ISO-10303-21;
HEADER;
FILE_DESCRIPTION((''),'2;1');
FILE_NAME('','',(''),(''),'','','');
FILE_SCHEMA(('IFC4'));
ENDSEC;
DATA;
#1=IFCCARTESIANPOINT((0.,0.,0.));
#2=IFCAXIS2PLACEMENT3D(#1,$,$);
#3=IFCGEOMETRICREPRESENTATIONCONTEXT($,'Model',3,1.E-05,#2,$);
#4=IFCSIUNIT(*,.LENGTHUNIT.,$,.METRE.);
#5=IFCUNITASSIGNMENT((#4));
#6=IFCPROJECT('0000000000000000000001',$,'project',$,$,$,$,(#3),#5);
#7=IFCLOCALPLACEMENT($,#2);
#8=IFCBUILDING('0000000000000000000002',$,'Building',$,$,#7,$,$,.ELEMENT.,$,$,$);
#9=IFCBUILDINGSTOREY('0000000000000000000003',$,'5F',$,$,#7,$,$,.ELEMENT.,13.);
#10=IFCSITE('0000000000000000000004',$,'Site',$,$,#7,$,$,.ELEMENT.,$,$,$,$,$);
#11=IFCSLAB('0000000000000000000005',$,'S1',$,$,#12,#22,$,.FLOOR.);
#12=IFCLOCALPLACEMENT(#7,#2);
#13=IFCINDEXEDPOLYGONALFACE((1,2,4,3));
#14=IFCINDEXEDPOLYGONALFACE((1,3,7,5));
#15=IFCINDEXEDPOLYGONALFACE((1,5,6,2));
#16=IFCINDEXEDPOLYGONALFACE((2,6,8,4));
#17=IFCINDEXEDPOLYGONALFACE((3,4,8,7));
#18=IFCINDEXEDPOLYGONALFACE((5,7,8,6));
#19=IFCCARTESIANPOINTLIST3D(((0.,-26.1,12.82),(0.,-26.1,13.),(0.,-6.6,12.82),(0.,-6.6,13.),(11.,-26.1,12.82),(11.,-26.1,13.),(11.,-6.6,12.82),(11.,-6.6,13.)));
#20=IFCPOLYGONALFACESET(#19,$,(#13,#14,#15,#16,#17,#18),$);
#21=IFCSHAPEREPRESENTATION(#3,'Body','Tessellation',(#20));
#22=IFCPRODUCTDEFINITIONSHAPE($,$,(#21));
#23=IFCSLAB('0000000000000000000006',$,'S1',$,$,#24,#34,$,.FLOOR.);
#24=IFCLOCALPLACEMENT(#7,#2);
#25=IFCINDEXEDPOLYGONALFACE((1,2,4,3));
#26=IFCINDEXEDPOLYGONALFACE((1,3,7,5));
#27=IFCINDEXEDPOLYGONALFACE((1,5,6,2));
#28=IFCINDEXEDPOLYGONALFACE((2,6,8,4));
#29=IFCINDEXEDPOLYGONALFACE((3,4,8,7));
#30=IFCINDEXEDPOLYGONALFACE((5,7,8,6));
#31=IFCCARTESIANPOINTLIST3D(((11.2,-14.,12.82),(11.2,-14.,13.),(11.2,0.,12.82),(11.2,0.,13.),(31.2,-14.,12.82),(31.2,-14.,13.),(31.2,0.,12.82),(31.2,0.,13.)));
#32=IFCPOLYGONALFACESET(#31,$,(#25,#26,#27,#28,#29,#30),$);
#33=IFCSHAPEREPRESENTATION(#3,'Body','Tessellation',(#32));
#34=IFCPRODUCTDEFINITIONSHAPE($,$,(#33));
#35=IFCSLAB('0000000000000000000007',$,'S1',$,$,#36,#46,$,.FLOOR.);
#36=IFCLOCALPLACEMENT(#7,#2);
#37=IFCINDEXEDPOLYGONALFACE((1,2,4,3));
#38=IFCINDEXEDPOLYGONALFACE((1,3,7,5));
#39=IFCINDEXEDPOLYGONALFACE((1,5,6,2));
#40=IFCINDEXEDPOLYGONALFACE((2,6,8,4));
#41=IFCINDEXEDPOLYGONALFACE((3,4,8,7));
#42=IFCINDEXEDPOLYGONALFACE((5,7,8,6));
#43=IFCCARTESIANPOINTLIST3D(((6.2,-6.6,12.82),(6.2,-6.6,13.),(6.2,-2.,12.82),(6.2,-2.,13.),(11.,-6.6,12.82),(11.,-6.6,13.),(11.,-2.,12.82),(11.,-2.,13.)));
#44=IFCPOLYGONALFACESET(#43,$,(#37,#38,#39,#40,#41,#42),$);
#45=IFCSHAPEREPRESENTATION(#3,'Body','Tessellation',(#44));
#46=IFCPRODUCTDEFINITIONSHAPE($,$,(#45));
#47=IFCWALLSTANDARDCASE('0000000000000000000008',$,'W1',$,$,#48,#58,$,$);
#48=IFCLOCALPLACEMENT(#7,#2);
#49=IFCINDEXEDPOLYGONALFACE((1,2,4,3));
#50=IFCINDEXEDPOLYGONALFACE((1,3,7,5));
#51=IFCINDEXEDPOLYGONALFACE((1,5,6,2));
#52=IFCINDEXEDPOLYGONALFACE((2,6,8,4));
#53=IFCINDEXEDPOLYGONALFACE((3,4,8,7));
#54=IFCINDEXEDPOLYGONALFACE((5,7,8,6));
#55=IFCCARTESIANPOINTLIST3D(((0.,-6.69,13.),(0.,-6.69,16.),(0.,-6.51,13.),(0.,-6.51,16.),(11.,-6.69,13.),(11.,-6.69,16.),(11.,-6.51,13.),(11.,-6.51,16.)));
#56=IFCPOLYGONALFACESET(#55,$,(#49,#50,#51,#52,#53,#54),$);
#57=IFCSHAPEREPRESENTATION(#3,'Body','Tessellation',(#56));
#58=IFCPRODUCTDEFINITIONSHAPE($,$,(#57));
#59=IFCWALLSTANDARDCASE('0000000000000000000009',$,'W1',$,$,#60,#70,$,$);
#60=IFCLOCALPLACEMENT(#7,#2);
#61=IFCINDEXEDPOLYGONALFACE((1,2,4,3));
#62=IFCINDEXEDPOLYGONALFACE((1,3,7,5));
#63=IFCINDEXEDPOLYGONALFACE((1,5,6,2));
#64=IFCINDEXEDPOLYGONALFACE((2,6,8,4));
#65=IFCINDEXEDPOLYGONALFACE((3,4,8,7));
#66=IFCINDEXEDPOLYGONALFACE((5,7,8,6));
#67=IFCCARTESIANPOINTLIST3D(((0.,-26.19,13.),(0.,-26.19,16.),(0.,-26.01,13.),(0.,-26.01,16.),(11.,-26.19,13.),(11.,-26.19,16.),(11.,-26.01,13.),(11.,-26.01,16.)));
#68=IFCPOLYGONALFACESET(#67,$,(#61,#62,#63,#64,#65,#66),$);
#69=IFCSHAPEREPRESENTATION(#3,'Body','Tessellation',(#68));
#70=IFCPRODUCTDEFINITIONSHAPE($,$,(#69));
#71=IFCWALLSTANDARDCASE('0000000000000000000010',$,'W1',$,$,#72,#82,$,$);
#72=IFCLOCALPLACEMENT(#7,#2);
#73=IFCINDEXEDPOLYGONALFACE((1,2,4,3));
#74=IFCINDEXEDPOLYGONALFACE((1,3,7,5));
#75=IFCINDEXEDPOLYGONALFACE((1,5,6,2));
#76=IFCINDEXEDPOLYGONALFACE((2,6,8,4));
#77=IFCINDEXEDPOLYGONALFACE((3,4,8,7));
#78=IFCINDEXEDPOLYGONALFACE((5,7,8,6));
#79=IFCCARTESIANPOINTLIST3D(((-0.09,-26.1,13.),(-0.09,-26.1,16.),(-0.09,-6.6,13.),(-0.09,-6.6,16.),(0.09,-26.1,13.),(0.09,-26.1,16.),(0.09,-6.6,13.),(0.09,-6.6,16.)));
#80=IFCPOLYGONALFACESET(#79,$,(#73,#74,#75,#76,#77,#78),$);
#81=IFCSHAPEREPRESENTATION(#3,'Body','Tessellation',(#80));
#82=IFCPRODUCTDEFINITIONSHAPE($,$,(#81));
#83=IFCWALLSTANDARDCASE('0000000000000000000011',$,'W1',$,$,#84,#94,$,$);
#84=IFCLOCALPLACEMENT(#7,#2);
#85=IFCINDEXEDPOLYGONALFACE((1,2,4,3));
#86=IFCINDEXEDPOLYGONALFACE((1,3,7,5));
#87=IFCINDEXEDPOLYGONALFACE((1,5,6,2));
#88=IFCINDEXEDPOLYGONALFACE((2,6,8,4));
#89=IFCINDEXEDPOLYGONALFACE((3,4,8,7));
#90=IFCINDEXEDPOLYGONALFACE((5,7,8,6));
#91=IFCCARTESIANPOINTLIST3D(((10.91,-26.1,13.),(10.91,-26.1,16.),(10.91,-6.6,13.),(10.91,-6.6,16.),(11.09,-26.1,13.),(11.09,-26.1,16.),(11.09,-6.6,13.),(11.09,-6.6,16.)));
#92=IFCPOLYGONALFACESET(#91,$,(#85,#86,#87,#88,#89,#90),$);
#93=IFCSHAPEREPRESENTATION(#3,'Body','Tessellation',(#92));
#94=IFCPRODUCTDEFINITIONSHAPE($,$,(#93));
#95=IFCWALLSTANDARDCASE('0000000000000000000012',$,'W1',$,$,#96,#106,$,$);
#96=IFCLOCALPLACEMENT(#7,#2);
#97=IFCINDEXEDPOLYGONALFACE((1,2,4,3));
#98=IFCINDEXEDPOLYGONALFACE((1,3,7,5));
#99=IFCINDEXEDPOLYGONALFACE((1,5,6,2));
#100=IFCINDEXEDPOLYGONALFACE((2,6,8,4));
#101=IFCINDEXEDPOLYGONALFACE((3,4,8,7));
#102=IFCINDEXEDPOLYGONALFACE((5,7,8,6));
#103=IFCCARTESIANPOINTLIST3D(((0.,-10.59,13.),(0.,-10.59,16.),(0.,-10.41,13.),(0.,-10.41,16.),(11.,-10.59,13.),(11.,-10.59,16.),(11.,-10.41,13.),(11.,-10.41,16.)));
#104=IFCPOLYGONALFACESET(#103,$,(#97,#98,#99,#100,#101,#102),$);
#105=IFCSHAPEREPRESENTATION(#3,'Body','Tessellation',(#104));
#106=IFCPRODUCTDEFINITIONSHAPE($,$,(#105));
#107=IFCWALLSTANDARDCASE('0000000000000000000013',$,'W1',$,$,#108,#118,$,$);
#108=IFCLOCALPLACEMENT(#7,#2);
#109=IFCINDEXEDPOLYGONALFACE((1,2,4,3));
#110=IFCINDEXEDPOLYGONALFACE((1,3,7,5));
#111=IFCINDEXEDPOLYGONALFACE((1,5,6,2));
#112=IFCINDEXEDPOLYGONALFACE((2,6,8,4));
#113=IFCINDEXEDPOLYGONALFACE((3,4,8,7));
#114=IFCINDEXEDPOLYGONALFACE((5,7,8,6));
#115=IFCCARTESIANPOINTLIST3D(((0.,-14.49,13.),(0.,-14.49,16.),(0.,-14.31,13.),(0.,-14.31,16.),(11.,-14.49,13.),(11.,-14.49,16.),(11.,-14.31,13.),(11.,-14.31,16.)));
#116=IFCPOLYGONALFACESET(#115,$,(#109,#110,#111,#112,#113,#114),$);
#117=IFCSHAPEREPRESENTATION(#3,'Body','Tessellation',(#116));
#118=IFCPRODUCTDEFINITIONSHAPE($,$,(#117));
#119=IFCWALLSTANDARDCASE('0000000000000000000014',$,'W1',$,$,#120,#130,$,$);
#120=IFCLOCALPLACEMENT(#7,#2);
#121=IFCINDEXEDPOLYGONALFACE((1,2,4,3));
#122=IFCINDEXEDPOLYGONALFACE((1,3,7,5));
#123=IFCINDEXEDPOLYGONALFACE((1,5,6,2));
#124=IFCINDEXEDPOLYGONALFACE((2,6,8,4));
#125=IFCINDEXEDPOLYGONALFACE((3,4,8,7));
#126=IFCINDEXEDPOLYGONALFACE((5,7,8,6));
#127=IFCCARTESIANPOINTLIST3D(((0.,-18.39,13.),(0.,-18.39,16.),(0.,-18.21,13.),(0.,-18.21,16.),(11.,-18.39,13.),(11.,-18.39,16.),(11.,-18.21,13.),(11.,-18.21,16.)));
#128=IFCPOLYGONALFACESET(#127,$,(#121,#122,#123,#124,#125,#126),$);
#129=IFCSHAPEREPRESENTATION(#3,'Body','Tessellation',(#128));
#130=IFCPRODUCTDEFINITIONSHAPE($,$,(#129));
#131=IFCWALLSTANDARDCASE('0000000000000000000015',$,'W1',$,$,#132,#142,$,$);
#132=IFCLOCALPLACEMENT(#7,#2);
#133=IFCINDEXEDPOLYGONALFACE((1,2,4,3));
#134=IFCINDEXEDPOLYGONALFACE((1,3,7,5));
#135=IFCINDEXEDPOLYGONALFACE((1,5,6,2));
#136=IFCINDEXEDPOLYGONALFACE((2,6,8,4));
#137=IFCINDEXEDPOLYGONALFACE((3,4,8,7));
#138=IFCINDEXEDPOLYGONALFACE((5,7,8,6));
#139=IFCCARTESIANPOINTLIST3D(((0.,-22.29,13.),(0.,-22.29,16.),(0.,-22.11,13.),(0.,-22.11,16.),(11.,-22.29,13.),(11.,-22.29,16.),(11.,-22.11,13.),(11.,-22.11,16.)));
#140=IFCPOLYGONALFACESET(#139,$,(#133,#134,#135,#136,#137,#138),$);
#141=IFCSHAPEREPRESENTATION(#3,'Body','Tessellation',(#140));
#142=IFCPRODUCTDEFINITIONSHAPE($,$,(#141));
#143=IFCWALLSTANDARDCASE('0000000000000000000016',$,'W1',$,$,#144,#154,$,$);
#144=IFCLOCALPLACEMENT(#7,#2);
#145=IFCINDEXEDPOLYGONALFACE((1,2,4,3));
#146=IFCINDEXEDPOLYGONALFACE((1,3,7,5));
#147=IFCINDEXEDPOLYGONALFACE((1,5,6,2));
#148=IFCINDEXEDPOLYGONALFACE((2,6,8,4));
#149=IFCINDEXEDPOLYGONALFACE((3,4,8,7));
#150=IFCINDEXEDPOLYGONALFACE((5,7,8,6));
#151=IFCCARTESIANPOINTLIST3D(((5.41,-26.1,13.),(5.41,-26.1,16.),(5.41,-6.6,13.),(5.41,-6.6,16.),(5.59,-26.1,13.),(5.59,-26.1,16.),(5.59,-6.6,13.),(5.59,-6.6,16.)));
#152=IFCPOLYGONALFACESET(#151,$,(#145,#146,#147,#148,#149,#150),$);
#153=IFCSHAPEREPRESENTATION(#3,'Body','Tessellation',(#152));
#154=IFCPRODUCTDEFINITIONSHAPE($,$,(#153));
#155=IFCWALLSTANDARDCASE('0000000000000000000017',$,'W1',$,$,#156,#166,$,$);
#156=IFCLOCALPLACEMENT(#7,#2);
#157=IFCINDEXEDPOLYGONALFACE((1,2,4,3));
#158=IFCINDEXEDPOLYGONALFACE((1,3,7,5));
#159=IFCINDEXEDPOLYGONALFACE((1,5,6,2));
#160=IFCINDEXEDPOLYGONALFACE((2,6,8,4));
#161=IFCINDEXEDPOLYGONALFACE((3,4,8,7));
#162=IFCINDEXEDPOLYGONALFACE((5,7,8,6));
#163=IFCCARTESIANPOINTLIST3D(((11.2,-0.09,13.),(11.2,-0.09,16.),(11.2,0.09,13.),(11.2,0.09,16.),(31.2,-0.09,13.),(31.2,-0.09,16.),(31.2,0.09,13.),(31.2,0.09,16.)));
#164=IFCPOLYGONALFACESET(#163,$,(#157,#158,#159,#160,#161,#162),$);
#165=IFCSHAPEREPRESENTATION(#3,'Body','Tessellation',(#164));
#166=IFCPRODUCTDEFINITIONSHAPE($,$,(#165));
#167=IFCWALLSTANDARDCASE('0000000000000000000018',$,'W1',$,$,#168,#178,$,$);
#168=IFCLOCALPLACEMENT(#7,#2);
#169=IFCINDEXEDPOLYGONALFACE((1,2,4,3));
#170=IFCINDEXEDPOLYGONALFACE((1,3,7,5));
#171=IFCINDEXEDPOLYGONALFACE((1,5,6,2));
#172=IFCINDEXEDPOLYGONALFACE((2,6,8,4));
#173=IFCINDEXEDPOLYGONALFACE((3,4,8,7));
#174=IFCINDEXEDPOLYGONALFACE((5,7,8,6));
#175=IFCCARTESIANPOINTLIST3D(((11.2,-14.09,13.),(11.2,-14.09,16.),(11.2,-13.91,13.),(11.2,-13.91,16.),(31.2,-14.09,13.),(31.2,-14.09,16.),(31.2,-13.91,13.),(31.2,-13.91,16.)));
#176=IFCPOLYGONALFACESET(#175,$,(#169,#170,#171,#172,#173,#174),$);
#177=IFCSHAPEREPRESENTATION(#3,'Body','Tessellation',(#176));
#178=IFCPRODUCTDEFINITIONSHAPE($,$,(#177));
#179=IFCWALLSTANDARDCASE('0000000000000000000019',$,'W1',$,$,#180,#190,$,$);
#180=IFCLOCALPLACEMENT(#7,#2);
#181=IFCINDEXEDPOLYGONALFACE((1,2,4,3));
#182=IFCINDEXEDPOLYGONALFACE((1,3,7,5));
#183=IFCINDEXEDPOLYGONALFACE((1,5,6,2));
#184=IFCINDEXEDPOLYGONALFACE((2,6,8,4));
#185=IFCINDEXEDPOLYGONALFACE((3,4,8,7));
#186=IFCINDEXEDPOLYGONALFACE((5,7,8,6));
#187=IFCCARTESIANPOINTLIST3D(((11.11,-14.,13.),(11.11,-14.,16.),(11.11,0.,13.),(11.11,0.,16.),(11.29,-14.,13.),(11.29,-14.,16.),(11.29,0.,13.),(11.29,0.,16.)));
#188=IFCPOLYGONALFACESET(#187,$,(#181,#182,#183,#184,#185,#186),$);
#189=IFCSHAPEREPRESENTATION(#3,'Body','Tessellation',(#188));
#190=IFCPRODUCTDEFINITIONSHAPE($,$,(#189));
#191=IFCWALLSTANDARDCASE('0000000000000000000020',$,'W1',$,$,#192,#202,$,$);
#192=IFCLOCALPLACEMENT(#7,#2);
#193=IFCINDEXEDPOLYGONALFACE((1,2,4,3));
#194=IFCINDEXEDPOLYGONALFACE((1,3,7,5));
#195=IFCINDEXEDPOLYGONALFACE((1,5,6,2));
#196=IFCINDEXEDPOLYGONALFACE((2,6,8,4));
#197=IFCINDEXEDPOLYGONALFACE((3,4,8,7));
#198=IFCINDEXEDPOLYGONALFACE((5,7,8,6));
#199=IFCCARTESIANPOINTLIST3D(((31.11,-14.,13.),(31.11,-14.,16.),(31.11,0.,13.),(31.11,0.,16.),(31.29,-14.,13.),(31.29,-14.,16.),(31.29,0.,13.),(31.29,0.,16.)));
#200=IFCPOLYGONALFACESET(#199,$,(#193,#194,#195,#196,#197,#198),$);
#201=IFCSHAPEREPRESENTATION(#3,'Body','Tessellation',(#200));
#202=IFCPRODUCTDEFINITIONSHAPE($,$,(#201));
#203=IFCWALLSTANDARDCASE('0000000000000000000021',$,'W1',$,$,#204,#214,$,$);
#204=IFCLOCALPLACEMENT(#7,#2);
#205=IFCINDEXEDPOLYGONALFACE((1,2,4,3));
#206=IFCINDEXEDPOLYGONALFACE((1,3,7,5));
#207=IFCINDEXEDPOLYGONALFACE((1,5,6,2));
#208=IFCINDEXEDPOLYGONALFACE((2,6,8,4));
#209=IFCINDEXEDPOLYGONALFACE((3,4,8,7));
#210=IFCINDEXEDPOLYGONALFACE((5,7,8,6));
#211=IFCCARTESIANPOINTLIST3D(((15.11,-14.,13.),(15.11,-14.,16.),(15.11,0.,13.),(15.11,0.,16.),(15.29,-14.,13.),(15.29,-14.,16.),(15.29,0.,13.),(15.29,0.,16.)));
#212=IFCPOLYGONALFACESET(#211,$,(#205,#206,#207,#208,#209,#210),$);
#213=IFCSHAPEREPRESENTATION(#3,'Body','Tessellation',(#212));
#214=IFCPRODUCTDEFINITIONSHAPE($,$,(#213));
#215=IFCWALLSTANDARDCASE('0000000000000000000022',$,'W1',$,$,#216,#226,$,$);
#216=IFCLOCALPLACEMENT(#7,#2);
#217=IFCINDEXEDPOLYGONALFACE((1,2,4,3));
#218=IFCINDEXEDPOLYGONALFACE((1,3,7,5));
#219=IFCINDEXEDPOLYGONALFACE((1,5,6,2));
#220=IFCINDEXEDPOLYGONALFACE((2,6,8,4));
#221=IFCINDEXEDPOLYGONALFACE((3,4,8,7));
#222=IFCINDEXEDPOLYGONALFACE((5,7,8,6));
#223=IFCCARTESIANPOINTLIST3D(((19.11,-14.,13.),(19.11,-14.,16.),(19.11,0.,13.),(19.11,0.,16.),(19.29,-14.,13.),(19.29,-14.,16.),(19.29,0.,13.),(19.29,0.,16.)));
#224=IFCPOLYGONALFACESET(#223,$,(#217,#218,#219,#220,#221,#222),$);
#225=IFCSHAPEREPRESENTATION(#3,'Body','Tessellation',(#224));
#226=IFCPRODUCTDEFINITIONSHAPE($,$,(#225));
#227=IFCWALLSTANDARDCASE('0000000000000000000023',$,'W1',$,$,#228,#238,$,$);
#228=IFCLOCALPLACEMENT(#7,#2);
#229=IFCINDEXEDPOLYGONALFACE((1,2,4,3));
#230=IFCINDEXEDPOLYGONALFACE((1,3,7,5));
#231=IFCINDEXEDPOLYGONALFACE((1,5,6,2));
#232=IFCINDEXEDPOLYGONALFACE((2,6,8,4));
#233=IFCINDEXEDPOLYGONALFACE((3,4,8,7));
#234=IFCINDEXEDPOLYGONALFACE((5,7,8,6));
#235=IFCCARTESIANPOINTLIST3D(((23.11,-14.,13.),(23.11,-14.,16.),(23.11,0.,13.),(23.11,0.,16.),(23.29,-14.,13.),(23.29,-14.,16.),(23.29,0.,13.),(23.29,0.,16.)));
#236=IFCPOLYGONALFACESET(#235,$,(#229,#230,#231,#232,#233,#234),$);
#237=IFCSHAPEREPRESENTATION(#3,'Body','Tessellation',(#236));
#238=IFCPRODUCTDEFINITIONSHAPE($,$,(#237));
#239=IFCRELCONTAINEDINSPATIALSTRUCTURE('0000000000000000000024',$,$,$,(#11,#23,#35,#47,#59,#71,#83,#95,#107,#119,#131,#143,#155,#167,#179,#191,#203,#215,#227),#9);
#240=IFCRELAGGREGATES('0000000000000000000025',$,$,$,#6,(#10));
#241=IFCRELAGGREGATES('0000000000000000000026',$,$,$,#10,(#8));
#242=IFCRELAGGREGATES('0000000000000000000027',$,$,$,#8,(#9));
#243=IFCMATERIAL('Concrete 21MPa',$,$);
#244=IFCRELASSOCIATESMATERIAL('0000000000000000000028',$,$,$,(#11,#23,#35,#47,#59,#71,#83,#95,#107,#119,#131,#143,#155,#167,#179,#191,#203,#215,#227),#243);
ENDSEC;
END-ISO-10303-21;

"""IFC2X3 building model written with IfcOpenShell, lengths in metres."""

from ifc_helpers import new_model, si_unit, frame, origin, origin_2d, place, context, project, spatial, rectangle, extrude, material, element, save


model = new_model("IFC2X3")

# Units and contexts
model_context = context("Model", 3, precision=1e-05, world=origin())
ifc_project = project(units=[si_unit("LENGTHUNIT", "METRE")], contexts=[model_context])

# Site, building, storey
placement = place(None, origin())
site = spatial("IfcSite", under=ifc_project, at=placement, Name="Site", CompositionType="ELEMENT")
building = spatial("IfcBuilding", under=site, at=placement, Name="Building", CompositionType="ELEMENT")
storey = spatial("IfcBuildingStorey", under=building, at=placement, Name="5F", CompositionType="ELEMENT", Elevation=13.0)

# Slabs
ifc_material_1 = material(Name="Concrete 21MPa")
slab_1_placement = place(None, frame((5.5, -16.35, 12.82)))
element("IfcSlab", 1, at=slab_1_placement, inside=storey, material=ifc_material_1, Name="S1", PredefinedType="FLOOR", context=model_context, shape_type="SweptSolid", body=[
    extrude(rectangle(XDim=11.0, YDim=19.5, at=origin_2d()), origin(), (0.0, 0.0, 1.0), 0.18),
])
slab_2_placement = place(None, frame((21.2, -7.0, 12.82)))
element("IfcSlab", 2, at=slab_2_placement, inside=storey, material=ifc_material_1, Name="S1", PredefinedType="FLOOR", context=model_context, shape_type="SweptSolid", body=[
    extrude(rectangle(XDim=20.0, YDim=14.0, at=origin_2d()), origin(), (0.0, 0.0, 1.0), 0.18),
])
slab_3_placement = place(None, frame((8.6, -4.3, 12.82)))
element("IfcSlab", 3, at=slab_3_placement, inside=storey, material=ifc_material_1, Name="S1", PredefinedType="FLOOR", context=model_context, shape_type="SweptSolid", body=[
    extrude(rectangle(XDim=4.8, YDim=4.6, at=origin_2d()), origin(), (0.0, 0.0, 1.0), 0.18),
])

# Walls
for number, where, name in (
    (4, (5.5, -6.6, 13.0), "W1"),
    (5, (5.5, -26.1, 13.0), "W1"),
):
    element("IfcWallStandardCase", number, at=place(None, frame(where)), inside=storey, material=ifc_material_1, Name=name, context=model_context, shape_type="SweptSolid", body=[
        extrude(rectangle(XDim=11.0, YDim=0.18, at=origin_2d()), origin(), (0.0, 0.0, 1.0), 3.0),
    ])
for number, where, name in (
    (6, (0.0, -16.35, 13.0), "W1"),
    (7, (11.0, -16.35, 13.0), "W1"),
):
    element("IfcWallStandardCase", number, at=place(None, frame(where)), inside=storey, material=ifc_material_1, Name=name, context=model_context, shape_type="SweptSolid", body=[
        extrude(rectangle(XDim=0.18, YDim=19.5, at=origin_2d()), origin(), (0.0, 0.0, 1.0), 3.0),
    ])
for number, where, name in (
    (8, (5.5, -10.5, 13.0), "W1"),
    (9, (5.5, -14.4, 13.0), "W1"),
    (10, (5.5, -18.3, 13.0), "W1"),
    (11, (5.5, -22.2, 13.0), "W1"),
):
    element("IfcWallStandardCase", number, at=place(None, frame(where)), inside=storey, material=ifc_material_1, Name=name, context=model_context, shape_type="SweptSolid", body=[
        extrude(rectangle(XDim=11.0, YDim=0.18, at=origin_2d()), origin(), (0.0, 0.0, 1.0), 3.0),
    ])
wall_1_placement = place(None, frame((5.5, -16.35, 13.0)))
element("IfcWallStandardCase", 12, at=wall_1_placement, inside=storey, material=ifc_material_1, Name="W1", context=model_context, shape_type="SweptSolid", body=[
    extrude(rectangle(XDim=0.18, YDim=19.5, at=origin_2d()), origin(), (0.0, 0.0, 1.0), 3.0),
])
for number, where, name in (
    (13, (21.2, 0.0, 13.0), "W1"),
    (14, (21.2, -14.0, 13.0), "W1"),
):
    element("IfcWallStandardCase", number, at=place(None, frame(where)), inside=storey, material=ifc_material_1, Name=name, context=model_context, shape_type="SweptSolid", body=[
        extrude(rectangle(XDim=20.0, YDim=0.18, at=origin_2d()), origin(), (0.0, 0.0, 1.0), 3.0),
    ])
for number, where, name in (
    (15, (11.2, -7.0, 13.0), "W1"),
    (16, (31.2, -7.0, 13.0), "W1"),
    (17, (15.2, -7.0, 13.0), "W1"),
    (18, (19.2, -7.0, 13.0), "W1"),
    (19, (23.2, -7.0, 13.0), "W1"),
):
    element("IfcWallStandardCase", number, at=place(None, frame(where)), inside=storey, material=ifc_material_1, Name=name, context=model_context, shape_type="SweptSolid", body=[
        extrude(rectangle(XDim=0.18, YDim=14.0, at=origin_2d()), origin(), (0.0, 0.0, 1.0), 3.0),
    ])

save(model, "model.ifc")
